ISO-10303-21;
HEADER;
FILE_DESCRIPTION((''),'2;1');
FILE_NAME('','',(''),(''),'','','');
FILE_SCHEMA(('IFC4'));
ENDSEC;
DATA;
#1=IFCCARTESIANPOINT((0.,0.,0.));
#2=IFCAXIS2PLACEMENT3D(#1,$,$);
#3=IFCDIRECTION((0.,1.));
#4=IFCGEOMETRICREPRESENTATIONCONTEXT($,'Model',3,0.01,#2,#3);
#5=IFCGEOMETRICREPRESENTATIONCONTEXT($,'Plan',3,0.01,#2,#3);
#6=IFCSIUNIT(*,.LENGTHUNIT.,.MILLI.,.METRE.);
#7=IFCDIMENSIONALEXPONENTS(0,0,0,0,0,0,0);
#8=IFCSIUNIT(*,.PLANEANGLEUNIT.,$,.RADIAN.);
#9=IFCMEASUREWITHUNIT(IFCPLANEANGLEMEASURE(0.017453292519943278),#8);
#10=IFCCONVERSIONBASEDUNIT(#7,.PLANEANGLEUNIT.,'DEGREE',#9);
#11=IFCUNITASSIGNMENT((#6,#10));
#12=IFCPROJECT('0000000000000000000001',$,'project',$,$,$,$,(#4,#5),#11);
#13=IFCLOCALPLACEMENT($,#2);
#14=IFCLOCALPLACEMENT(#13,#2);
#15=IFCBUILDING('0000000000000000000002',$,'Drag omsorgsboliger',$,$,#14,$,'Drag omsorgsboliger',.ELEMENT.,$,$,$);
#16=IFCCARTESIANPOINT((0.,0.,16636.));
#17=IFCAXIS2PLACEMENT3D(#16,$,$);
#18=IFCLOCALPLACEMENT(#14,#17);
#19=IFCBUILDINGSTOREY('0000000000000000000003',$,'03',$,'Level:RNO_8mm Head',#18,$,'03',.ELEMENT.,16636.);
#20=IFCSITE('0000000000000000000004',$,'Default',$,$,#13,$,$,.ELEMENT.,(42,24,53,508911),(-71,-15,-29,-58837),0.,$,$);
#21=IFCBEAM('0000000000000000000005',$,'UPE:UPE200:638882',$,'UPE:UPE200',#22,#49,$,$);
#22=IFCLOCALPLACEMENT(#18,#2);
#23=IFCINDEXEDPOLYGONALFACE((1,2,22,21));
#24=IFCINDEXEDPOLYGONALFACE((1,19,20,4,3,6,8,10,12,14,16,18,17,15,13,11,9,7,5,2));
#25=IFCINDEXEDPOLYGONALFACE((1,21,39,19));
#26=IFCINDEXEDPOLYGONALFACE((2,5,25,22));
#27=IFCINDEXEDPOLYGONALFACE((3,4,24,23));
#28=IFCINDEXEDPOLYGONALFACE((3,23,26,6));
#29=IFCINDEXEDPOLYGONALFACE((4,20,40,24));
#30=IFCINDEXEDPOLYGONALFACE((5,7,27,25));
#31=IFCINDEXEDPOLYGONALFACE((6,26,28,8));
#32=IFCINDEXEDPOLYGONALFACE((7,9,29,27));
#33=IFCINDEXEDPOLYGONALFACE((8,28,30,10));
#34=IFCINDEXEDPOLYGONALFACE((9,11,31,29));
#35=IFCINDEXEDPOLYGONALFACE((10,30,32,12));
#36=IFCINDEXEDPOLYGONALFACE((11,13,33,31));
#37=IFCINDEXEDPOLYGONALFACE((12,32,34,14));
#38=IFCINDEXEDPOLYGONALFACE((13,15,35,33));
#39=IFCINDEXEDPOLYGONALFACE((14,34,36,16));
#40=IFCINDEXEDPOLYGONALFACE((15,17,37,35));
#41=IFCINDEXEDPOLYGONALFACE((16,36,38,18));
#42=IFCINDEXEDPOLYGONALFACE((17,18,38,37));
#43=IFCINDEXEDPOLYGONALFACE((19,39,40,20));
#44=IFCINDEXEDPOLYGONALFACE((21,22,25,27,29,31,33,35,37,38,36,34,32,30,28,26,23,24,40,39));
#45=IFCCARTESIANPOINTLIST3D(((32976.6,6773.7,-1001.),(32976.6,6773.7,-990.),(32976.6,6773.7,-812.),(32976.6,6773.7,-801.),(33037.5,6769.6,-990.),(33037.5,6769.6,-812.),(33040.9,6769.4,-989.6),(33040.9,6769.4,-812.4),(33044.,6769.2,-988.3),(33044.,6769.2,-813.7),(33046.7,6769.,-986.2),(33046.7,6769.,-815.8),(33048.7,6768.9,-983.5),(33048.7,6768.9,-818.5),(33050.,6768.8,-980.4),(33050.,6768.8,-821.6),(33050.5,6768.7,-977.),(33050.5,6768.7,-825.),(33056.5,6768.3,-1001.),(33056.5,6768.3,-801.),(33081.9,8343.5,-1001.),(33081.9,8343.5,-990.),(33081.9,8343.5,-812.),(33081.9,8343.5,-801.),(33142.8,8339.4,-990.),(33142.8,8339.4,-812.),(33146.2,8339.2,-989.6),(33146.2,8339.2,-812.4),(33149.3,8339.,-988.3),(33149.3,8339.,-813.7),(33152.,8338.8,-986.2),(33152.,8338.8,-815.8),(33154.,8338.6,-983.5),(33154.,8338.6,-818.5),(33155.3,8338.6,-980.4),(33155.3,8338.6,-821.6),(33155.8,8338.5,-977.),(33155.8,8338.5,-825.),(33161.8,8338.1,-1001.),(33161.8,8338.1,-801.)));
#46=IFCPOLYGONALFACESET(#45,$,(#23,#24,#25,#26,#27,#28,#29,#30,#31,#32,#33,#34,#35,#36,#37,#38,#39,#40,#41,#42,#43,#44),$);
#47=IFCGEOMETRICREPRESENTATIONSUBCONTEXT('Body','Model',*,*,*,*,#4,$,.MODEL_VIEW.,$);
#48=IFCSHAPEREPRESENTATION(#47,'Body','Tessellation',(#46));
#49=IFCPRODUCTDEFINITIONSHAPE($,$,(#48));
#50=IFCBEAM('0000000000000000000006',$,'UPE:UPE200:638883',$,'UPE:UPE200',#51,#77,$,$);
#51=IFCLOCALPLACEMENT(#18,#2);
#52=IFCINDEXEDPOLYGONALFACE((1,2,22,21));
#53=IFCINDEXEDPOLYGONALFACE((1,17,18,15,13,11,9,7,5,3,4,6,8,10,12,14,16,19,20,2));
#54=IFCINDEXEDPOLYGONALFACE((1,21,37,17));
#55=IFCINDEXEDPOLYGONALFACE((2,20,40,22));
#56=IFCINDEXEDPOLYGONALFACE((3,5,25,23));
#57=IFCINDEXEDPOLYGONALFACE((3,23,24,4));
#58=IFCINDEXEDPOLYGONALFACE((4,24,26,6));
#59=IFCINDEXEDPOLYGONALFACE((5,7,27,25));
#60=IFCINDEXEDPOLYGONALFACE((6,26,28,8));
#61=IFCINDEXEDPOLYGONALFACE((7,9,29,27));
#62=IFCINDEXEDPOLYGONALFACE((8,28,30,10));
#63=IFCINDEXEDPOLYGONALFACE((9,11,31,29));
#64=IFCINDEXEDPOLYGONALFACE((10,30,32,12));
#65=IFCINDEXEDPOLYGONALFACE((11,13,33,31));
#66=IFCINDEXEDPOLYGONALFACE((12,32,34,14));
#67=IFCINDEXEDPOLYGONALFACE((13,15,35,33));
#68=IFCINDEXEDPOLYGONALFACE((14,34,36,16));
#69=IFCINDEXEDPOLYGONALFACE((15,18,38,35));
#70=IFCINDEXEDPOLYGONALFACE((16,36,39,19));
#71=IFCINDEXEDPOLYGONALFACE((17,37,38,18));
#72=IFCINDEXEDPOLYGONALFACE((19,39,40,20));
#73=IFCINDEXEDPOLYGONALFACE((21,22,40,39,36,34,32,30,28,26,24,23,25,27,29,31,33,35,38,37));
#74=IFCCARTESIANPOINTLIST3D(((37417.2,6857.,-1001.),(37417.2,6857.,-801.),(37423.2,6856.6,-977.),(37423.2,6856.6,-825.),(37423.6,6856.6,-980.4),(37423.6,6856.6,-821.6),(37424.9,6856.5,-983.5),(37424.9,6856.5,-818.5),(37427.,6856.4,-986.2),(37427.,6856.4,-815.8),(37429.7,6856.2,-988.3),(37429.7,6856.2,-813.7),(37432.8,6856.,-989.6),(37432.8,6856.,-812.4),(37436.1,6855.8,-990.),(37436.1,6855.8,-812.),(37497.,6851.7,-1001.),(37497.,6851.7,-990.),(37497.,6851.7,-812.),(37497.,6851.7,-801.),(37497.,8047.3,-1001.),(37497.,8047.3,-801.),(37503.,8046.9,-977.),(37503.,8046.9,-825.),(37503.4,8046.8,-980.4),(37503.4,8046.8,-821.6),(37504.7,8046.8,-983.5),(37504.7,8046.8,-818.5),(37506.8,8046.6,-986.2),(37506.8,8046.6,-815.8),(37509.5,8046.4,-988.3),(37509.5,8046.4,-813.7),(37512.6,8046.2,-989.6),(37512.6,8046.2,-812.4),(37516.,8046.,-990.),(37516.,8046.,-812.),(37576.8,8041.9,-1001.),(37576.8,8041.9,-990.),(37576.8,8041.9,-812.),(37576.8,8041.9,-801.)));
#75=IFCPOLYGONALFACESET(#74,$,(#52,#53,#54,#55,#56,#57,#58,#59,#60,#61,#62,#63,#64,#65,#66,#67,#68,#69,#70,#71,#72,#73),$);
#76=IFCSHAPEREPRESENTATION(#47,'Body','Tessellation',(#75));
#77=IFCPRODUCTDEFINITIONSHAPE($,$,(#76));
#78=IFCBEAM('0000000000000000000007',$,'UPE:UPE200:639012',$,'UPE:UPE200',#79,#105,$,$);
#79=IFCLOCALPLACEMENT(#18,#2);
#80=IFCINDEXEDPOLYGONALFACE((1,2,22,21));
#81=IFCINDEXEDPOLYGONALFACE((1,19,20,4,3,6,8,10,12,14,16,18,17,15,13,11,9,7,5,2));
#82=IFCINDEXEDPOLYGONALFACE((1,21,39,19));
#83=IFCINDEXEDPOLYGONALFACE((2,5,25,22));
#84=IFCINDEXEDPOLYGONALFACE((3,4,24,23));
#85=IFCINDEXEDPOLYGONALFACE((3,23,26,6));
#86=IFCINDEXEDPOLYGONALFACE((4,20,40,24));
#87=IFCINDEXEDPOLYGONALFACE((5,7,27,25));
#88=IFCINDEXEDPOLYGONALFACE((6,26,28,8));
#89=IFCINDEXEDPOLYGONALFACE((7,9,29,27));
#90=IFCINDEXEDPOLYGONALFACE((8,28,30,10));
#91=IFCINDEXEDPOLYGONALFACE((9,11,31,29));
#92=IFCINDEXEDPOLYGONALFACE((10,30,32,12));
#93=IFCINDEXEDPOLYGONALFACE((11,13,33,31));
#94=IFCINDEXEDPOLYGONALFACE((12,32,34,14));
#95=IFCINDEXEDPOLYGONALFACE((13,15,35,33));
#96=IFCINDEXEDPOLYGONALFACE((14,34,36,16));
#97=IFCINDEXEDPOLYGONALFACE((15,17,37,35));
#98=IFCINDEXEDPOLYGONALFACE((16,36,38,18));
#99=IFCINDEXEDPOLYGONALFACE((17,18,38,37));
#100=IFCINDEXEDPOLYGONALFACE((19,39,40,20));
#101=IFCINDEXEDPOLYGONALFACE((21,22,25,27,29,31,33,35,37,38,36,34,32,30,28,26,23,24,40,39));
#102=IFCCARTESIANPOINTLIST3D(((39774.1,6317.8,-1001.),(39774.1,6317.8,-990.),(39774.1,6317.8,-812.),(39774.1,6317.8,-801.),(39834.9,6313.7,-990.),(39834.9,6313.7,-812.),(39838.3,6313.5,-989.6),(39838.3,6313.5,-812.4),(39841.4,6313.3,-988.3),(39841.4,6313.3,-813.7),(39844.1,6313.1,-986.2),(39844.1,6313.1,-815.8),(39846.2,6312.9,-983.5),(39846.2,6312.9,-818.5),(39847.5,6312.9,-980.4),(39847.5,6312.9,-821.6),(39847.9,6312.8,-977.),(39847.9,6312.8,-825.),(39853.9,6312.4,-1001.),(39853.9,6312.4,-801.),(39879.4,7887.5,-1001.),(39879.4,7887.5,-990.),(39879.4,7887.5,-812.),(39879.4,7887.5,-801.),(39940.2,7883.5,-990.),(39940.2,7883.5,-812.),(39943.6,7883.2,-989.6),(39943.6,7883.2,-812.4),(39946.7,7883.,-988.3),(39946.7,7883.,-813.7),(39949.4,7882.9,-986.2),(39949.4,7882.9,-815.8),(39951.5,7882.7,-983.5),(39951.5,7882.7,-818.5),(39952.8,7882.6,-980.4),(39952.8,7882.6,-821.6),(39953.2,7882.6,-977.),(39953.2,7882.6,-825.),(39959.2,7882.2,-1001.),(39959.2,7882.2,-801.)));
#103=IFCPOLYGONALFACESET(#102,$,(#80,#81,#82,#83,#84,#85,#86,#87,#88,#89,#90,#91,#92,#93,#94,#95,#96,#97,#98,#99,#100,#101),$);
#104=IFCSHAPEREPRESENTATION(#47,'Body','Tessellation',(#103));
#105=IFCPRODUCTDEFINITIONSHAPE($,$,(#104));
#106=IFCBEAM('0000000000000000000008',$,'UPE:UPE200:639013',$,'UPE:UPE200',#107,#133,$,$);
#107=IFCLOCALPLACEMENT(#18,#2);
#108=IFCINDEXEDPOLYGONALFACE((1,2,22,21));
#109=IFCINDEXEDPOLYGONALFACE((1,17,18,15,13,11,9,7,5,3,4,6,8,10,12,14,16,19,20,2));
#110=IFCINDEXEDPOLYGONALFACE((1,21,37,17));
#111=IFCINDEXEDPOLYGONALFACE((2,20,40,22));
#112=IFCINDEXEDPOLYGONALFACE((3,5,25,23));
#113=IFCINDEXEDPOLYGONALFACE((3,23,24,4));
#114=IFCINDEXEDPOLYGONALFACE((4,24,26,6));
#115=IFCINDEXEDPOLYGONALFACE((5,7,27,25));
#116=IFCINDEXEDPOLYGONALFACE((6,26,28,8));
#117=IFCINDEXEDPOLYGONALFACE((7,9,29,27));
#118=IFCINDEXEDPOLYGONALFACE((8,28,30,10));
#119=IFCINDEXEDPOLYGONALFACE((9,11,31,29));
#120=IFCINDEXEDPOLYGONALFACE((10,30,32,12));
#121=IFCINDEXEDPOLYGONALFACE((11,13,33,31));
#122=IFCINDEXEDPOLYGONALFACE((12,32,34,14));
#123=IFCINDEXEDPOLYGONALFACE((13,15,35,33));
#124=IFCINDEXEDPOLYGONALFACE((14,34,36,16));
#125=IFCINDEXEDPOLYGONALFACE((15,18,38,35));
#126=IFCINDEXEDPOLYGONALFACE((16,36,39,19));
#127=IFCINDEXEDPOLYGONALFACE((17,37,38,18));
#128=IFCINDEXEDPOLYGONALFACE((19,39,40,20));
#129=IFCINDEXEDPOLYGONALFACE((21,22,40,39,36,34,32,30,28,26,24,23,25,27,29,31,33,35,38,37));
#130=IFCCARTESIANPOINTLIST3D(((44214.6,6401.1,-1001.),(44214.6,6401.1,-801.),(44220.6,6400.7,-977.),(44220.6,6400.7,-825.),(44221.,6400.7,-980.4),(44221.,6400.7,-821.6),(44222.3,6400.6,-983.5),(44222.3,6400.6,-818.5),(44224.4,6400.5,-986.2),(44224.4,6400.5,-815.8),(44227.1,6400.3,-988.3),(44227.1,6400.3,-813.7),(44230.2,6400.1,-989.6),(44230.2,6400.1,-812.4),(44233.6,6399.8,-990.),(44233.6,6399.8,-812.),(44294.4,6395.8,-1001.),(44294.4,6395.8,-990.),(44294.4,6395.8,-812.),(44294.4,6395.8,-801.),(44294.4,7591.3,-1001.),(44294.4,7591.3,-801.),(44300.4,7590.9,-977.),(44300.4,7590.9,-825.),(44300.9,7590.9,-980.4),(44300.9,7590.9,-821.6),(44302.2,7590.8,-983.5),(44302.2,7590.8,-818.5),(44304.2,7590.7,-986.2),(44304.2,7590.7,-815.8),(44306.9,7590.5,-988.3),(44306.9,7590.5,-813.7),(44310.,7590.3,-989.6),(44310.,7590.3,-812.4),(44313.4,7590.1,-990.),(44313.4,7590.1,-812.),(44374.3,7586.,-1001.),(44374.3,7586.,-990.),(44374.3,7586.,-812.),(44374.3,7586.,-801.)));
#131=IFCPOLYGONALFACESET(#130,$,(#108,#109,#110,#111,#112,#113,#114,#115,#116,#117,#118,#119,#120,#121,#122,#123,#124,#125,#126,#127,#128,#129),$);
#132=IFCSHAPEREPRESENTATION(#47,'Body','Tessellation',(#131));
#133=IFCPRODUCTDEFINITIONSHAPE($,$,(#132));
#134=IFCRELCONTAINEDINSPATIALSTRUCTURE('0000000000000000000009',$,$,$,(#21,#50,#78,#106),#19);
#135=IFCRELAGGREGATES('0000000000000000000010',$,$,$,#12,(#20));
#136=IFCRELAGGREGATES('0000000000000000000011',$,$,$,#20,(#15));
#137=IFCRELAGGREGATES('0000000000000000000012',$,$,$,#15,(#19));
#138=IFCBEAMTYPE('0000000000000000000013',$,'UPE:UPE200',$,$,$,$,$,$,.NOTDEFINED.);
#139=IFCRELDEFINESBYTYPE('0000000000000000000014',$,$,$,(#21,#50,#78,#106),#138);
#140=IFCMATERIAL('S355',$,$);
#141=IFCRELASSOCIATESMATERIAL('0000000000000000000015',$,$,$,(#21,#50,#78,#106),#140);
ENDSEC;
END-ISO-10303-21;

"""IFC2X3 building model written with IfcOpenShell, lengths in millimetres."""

from ifc_helpers import new_model, entity, si_unit, converted_unit, direction, frame, frame_2d, origin, place, context, subcontext, project, spatial, polyline, circle_curve, parameter, trimmed, segment, composite_curve, outline, extrude, material, type_object, element, save


model = new_model("IFC2X3")

# Units and contexts
model_context = context("Model", 3, precision=0.01, world=origin(), true_north=direction((0.0, 1.0)))
plan_context = context("Plan", 3, precision=0.01, world=origin(), true_north=direction((0.0, 1.0)))
body_context = subcontext(model_context, "Body", "Model", "MODEL_VIEW")
ifc_project = project(units=[si_unit("LENGTHUNIT", "METRE", prefix="MILLI"), converted_unit("PLANEANGLEUNIT", "DEGREE", entity("IfcPlaneAngleMeasure", 0.017453292519943278), si_unit("PLANEANGLEUNIT", "RADIAN"), dimensions=[0, 0, 0, 0, 0, 0, 0])], contexts=[model_context, plan_context])

# Site, building, storey
site_placement = place(None, origin())
site = spatial("IfcSite", under=ifc_project, at=site_placement, Name="Default", CompositionType="ELEMENT", RefLatitude=(42, 24, 53, 508911), RefLongitude=(-71, -15, -29, -58837), RefElevation=0.0)
building_placement = place(site_placement, origin())
building = spatial("IfcBuilding", under=site, at=building_placement, Name="Drag omsorgsboliger", LongName="Drag omsorgsboliger", CompositionType="ELEMENT")
storey_placement = place(building_placement, frame((0.0, 0.0, 16636.0)))
storey = spatial("IfcBuildingStorey", under=building, at=storey_placement, Name="03", ObjectType="Level:RNO_8mm Head", LongName="03", CompositionType="ELEMENT", Elevation=16636.0)

# Beams
ifc_material = material(Name="S355")
beam_type_1 = type_object("IfcBeamType", Name="UPE:UPE200", PredefinedType="NOTDEFINED")
beam_1_placement = place(storey_placement, frame((33136.2, 8339.8, -801.0), z_axis=(0.0, 0.0, 1.0), x_axis=(-0.066923, -0.997758, 0.0)))
element("IfcBeam", 1, at=beam_1_placement, inside=storey, type_object=beam_type_1, material=ifc_material, Name="UPE:UPE200:638882", ObjectType="UPE:UPE200", context=body_context, shape_type="SweptSolid", body=[
    extrude(outline(composite_curve([segment(polyline([(-100.0, -43.0), (-89.0, -43.0)]), True, "CONTINUOUS"), segment(polyline([(-89.0, -43.0), (-89.0, 18.0)]), True, "CONTINUOUS"), segment(trimmed(circle_curve(frame_2d((-76.0, 18.0), x_axis=(-1.0, 0.0)), 13.0), [parameter(270.0)], [parameter(0.0)], True, "PARAMETER"), False, "CONTINUOUS"), segment(polyline([(-76.0, 31.0), (76.0, 31.0)]), True, "CONTINUOUS"), segment(trimmed(circle_curve(frame_2d((76.0, 18.0), x_axis=(0.0, 1.0)), 13.0), [parameter(270.0)], [parameter(0.0)], True, "PARAMETER"), False, "CONTINUOUS"), segment(polyline([(89.0, 18.0), (89.0, -43.0)]), True, "CONTINUOUS"), segment(polyline([(89.0, -43.0), (100.0, -43.0)]), True, "CONTINUOUS"), segment(polyline([(100.0, -43.0), (100.0, 37.0)]), True, "CONTINUOUS"), segment(polyline([(100.0, 37.0), (-100.0, 37.0)]), True, "CONTINUOUS"), segment(polyline([(-100.0, 37.0), (-100.0, -43.0)]), True, "CONTINUOUS")], self_intersect=False)), frame((0.0, -11.4, -100.0), z_axis=(1.0, 0.0, 0.0), x_axis=(0.0, 0.0, -1.0)), (0.0, 0.0, 1.0), 1573.3),
])
beam_2_placement = place(storey_placement, frame((37527.9, 8125.9, -801.0), z_axis=(0.0, 0.0, 1.0), x_axis=(-0.066923, -0.997758, 0.0)))
element("IfcBeam", 2, at=beam_2_placement, inside=storey, type_object=beam_type_1, material=ifc_material, Name="UPE:UPE200:638883", ObjectType="UPE:UPE200", context=body_context, shape_type="SweptSolid", body=[
    extrude(outline(composite_curve([segment(polyline([(-100.0, -37.0), (100.0, -37.0)]), True, "CONTINUOUS"), segment(polyline([(100.0, -37.0), (100.0, 43.0)]), True, "CONTINUOUS"), segment(polyline([(100.0, 43.0), (89.0, 43.0)]), True, "CONTINUOUS"), segment(polyline([(89.0, 43.0), (89.0, -18.0)]), True, "CONTINUOUS"), segment(trimmed(circle_curve(frame_2d((76.0, -18.0), x_axis=(1.0, 0.0)), 13.0), [parameter(270.0)], [parameter(0.0)], True, "PARAMETER"), False, "CONTINUOUS"), segment(polyline([(76.0, -31.0), (-76.0, -31.0)]), True, "CONTINUOUS"), segment(trimmed(circle_curve(frame_2d((-76.0, -18.0), x_axis=(0.0, -1.0)), 13.0), [parameter(270.0)], [parameter(0.0)], True, "PARAMETER"), False, "CONTINUOUS"), segment(polyline([(-89.0, -18.0), (-89.0, 43.0)]), True, "CONTINUOUS"), segment(polyline([(-89.0, 43.0), (-100.0, 43.0)]), True, "CONTINUOUS"), segment(polyline([(-100.0, 43.0), (-100.0, -37.0)]), True, "CONTINUOUS")], self_intersect=False)), frame((80.5, 11.4, -100.0), z_axis=(1.0, 0.0, 0.0), x_axis=(0.0, 0.0, -1.0)), (0.0, 0.0, 1.0), 1192.9),
])
beam_3_placement = place(storey_placement, frame((39933.6, 7883.9, -801.0), z_axis=(0.0, 0.0, 1.0), x_axis=(-0.066923, -0.997758, 0.0)))
element("IfcBeam", 3, at=beam_3_placement, inside=storey, type_object=beam_type_1, material=ifc_material, Name="UPE:UPE200:639012", ObjectType="UPE:UPE200", context=body_context, shape_type="SweptSolid", body=[
    extrude(outline(composite_curve([segment(polyline([(-100.0, -43.0), (-89.0, -43.0)]), True, "CONTINUOUS"), segment(polyline([(-89.0, -43.0), (-89.0, 18.0)]), True, "CONTINUOUS"), segment(trimmed(circle_curve(frame_2d((-76.0, 18.0), x_axis=(-1.0, 0.0)), 13.0), [parameter(270.0)], [parameter(0.0)], True, "PARAMETER"), False, "CONTINUOUS"), segment(polyline([(-76.0, 31.0), (76.0, 31.0)]), True, "CONTINUOUS"), segment(trimmed(circle_curve(frame_2d((76.0, 18.0), x_axis=(0.0, 1.0)), 13.0), [parameter(270.0)], [parameter(0.0)], True, "PARAMETER"), False, "CONTINUOUS"), segment(polyline([(89.0, 18.0), (89.0, -43.0)]), True, "CONTINUOUS"), segment(polyline([(89.0, -43.0), (100.0, -43.0)]), True, "CONTINUOUS"), segment(polyline([(100.0, -43.0), (100.0, 37.0)]), True, "CONTINUOUS"), segment(polyline([(100.0, 37.0), (-100.0, 37.0)]), True, "CONTINUOUS"), segment(polyline([(-100.0, 37.0), (-100.0, -43.0)]), True, "CONTINUOUS")], self_intersect=False)), frame((0.0, -11.4, -100.0), z_axis=(1.0, 0.0, 0.0), x_axis=(0.0, 0.0, -1.0)), (0.0, 0.0, 1.0), 1573.3),
])
beam_4_placement = place(storey_placement, frame((44325.4, 7670.0, -801.0), z_axis=(0.0, 0.0, 1.0), x_axis=(-0.066923, -0.997758, 0.0)))
element("IfcBeam", 4, at=beam_4_placement, inside=storey, type_object=beam_type_1, material=ifc_material, Name="UPE:UPE200:639013", ObjectType="UPE:UPE200", context=body_context, shape_type="SweptSolid", body=[
    extrude(outline(composite_curve([segment(polyline([(-100.0, -37.0), (100.0, -37.0)]), True, "CONTINUOUS"), segment(polyline([(100.0, -37.0), (100.0, 43.0)]), True, "CONTINUOUS"), segment(polyline([(100.0, 43.0), (89.0, 43.0)]), True, "CONTINUOUS"), segment(polyline([(89.0, 43.0), (89.0, -18.0)]), True, "CONTINUOUS"), segment(trimmed(circle_curve(frame_2d((76.0, -18.0), x_axis=(1.0, 0.0)), 13.0), [parameter(270.0)], [parameter(0.0)], True, "PARAMETER"), False, "CONTINUOUS"), segment(polyline([(76.0, -31.0), (-76.0, -31.0)]), True, "CONTINUOUS"), segment(trimmed(circle_curve(frame_2d((-76.0, -18.0), x_axis=(0.0, -1.0)), 13.0), [parameter(270.0)], [parameter(0.0)], True, "PARAMETER"), False, "CONTINUOUS"), segment(polyline([(-89.0, -18.0), (-89.0, 43.0)]), True, "CONTINUOUS"), segment(polyline([(-89.0, 43.0), (-100.0, 43.0)]), True, "CONTINUOUS"), segment(polyline([(-100.0, 43.0), (-100.0, -37.0)]), True, "CONTINUOUS")], self_intersect=False)), frame((80.5, 11.4, -100.0), z_axis=(1.0, 0.0, 0.0), x_axis=(0.0, 0.0, -1.0)), (0.0, 0.0, 1.0), 1192.9),
])

save(model, "model.ifc")
